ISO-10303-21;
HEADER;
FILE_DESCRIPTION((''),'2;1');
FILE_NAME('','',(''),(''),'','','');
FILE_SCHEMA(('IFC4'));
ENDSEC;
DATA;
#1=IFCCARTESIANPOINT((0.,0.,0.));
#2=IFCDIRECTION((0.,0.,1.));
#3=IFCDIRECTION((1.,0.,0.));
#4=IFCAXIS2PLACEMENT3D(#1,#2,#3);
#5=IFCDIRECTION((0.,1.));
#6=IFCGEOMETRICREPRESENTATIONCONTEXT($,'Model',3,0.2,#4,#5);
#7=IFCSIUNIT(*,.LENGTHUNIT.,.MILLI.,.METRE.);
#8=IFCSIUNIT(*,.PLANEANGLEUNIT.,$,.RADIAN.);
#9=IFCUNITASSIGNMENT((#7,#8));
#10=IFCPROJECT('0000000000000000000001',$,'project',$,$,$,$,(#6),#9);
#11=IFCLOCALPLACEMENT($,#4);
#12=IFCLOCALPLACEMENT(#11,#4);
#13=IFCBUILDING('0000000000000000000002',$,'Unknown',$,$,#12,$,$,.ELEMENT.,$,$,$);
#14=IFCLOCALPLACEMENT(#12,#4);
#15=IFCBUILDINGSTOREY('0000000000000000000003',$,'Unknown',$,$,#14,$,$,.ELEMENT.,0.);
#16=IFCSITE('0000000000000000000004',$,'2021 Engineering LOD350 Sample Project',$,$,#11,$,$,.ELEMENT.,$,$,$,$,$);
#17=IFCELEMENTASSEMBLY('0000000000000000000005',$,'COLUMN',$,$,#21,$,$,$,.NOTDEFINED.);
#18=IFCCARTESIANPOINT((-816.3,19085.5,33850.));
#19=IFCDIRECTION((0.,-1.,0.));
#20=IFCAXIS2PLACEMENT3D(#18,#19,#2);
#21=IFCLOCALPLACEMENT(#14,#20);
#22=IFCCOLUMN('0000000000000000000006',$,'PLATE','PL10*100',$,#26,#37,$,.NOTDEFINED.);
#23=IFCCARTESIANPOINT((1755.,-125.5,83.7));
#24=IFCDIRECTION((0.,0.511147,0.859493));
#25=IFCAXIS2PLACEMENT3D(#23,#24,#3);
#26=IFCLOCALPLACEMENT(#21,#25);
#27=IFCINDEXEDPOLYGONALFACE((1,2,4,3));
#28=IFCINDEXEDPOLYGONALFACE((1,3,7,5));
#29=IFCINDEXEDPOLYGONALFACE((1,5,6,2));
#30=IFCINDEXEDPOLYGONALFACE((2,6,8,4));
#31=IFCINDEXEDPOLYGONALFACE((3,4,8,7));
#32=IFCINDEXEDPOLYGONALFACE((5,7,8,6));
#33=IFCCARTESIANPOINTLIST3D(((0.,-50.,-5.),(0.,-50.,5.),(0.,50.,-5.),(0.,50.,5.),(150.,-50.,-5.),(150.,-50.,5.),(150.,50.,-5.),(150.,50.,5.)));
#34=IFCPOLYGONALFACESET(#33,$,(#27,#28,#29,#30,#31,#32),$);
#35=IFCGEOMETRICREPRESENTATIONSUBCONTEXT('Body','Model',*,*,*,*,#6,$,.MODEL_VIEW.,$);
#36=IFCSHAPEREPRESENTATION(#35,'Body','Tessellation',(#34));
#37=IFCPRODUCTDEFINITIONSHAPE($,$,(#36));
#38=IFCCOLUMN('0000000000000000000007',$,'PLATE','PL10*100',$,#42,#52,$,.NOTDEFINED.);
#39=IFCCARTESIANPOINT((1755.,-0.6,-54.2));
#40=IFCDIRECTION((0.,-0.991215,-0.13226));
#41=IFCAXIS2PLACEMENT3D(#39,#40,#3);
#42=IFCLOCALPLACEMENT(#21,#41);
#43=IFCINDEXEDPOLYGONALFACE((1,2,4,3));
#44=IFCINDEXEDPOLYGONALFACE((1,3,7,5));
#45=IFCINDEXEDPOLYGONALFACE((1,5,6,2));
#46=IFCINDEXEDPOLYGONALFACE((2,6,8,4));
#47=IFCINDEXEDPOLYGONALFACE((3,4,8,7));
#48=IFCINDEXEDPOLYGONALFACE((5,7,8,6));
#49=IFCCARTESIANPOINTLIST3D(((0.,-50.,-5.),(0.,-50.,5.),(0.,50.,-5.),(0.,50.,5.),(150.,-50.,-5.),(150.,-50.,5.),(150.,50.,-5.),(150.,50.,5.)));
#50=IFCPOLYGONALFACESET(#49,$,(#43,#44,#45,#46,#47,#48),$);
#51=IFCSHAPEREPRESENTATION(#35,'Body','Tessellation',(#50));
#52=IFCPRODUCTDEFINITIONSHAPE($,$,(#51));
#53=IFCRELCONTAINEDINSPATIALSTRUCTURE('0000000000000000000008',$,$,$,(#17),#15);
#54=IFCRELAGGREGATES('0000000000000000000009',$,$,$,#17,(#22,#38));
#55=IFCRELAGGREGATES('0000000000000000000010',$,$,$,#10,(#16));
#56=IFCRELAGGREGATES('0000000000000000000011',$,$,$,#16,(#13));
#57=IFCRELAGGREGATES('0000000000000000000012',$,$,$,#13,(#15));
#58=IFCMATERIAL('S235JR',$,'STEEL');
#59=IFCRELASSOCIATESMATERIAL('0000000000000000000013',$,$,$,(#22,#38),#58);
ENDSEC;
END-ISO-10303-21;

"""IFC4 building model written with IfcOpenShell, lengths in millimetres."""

from ifc_helpers import new_model, si_unit, direction, frame, origin_with_axes, place, context, subcontext, project, spatial, line, indexed_curve, outline, extrude, material, element, aggregate, save


model = new_model("IFC4")

# Units and contexts
model_context = context("Model", 3, precision=0.2, world=origin_with_axes(), true_north=direction((0.0, 1.0)))
body_context = subcontext(model_context, "Body", "Model", "MODEL_VIEW")
ifc_project = project(units=[si_unit("LENGTHUNIT", "METRE", prefix="MILLI"), si_unit("PLANEANGLEUNIT", "RADIAN")], contexts=[model_context])

# Site, building, storey
site_placement = place(None, origin_with_axes())
site = spatial("IfcSite", under=ifc_project, at=site_placement, Name="2021 Engineering LOD350 Sample Project", CompositionType="ELEMENT")
building_placement = place(site_placement, origin_with_axes())
building = spatial("IfcBuilding", under=site, at=building_placement, Name="Unknown", CompositionType="ELEMENT")
storey_placement = place(building_placement, origin_with_axes())
storey = spatial("IfcBuildingStorey", under=building, at=storey_placement, Name="Unknown", CompositionType="ELEMENT", Elevation=0.0)

# Shared definitions
ifc_material_1 = material(Name="S235JR", Category="STEEL")

# Element assembly, columns
assembly_1_placement = place(storey_placement, frame((-816.3, 19085.5, 33850.0), z_axis=(0.0, -1.0, 0.0), x_axis=(0.0, 0.0, 1.0)))
assembly_1 = element("IfcElementAssembly", 1, at=assembly_1_placement, inside=storey, Name="COLUMN", PredefinedType="NOTDEFINED")
column_1_placement = place(assembly_1_placement, frame((1755.0, -125.5, 83.7), z_axis=(0.0, 0.511147, 0.859493), x_axis=(1.0, 0.0, 0.0)))
column_1 = element("IfcColumn", 2, at=column_1_placement, material=ifc_material_1, Name="PLATE", Description="PL10*100", PredefinedType="NOTDEFINED", context=body_context, shape_type="SolidModel", body=[
    extrude(outline(indexed_curve([(-5.0, -50.0), (5.0, -50.0), (5.0, 50.0), (-5.0, 50.0)], segments=[line(1, 2, 3, 4, 1)])), frame((0.0, 0.0, 0.0), z_axis=(-1.0, 0.0, 0.0), x_axis=(0.0, 0.0, 1.0)), (0.0, 0.0, -1.0), 150.0),
])
column_2_placement = place(assembly_1_placement, frame((1755.0, -0.6, -54.2), z_axis=(0.0, -0.991215, -0.13226), x_axis=(1.0, 0.0, 0.0)))
column_2 = element("IfcColumn", 3, at=column_2_placement, material=ifc_material_1, Name="PLATE", Description="PL10*100", PredefinedType="NOTDEFINED", context=body_context, shape_type="SolidModel", body=[
    extrude(outline(indexed_curve([(-5.0, -50.0), (5.0, -50.0), (5.0, 50.0), (-5.0, 50.0)], segments=[line(1, 2, 3, 4, 1)])), frame((0.0, 0.0, 0.0), z_axis=(-1.0, 0.0, 0.0), x_axis=(0.0, 0.0, 1.0)), (0.0, 0.0, -1.0), 150.0),
])

aggregate(assembly_1, [column_1, column_2])

save(model, "model.ifc")
